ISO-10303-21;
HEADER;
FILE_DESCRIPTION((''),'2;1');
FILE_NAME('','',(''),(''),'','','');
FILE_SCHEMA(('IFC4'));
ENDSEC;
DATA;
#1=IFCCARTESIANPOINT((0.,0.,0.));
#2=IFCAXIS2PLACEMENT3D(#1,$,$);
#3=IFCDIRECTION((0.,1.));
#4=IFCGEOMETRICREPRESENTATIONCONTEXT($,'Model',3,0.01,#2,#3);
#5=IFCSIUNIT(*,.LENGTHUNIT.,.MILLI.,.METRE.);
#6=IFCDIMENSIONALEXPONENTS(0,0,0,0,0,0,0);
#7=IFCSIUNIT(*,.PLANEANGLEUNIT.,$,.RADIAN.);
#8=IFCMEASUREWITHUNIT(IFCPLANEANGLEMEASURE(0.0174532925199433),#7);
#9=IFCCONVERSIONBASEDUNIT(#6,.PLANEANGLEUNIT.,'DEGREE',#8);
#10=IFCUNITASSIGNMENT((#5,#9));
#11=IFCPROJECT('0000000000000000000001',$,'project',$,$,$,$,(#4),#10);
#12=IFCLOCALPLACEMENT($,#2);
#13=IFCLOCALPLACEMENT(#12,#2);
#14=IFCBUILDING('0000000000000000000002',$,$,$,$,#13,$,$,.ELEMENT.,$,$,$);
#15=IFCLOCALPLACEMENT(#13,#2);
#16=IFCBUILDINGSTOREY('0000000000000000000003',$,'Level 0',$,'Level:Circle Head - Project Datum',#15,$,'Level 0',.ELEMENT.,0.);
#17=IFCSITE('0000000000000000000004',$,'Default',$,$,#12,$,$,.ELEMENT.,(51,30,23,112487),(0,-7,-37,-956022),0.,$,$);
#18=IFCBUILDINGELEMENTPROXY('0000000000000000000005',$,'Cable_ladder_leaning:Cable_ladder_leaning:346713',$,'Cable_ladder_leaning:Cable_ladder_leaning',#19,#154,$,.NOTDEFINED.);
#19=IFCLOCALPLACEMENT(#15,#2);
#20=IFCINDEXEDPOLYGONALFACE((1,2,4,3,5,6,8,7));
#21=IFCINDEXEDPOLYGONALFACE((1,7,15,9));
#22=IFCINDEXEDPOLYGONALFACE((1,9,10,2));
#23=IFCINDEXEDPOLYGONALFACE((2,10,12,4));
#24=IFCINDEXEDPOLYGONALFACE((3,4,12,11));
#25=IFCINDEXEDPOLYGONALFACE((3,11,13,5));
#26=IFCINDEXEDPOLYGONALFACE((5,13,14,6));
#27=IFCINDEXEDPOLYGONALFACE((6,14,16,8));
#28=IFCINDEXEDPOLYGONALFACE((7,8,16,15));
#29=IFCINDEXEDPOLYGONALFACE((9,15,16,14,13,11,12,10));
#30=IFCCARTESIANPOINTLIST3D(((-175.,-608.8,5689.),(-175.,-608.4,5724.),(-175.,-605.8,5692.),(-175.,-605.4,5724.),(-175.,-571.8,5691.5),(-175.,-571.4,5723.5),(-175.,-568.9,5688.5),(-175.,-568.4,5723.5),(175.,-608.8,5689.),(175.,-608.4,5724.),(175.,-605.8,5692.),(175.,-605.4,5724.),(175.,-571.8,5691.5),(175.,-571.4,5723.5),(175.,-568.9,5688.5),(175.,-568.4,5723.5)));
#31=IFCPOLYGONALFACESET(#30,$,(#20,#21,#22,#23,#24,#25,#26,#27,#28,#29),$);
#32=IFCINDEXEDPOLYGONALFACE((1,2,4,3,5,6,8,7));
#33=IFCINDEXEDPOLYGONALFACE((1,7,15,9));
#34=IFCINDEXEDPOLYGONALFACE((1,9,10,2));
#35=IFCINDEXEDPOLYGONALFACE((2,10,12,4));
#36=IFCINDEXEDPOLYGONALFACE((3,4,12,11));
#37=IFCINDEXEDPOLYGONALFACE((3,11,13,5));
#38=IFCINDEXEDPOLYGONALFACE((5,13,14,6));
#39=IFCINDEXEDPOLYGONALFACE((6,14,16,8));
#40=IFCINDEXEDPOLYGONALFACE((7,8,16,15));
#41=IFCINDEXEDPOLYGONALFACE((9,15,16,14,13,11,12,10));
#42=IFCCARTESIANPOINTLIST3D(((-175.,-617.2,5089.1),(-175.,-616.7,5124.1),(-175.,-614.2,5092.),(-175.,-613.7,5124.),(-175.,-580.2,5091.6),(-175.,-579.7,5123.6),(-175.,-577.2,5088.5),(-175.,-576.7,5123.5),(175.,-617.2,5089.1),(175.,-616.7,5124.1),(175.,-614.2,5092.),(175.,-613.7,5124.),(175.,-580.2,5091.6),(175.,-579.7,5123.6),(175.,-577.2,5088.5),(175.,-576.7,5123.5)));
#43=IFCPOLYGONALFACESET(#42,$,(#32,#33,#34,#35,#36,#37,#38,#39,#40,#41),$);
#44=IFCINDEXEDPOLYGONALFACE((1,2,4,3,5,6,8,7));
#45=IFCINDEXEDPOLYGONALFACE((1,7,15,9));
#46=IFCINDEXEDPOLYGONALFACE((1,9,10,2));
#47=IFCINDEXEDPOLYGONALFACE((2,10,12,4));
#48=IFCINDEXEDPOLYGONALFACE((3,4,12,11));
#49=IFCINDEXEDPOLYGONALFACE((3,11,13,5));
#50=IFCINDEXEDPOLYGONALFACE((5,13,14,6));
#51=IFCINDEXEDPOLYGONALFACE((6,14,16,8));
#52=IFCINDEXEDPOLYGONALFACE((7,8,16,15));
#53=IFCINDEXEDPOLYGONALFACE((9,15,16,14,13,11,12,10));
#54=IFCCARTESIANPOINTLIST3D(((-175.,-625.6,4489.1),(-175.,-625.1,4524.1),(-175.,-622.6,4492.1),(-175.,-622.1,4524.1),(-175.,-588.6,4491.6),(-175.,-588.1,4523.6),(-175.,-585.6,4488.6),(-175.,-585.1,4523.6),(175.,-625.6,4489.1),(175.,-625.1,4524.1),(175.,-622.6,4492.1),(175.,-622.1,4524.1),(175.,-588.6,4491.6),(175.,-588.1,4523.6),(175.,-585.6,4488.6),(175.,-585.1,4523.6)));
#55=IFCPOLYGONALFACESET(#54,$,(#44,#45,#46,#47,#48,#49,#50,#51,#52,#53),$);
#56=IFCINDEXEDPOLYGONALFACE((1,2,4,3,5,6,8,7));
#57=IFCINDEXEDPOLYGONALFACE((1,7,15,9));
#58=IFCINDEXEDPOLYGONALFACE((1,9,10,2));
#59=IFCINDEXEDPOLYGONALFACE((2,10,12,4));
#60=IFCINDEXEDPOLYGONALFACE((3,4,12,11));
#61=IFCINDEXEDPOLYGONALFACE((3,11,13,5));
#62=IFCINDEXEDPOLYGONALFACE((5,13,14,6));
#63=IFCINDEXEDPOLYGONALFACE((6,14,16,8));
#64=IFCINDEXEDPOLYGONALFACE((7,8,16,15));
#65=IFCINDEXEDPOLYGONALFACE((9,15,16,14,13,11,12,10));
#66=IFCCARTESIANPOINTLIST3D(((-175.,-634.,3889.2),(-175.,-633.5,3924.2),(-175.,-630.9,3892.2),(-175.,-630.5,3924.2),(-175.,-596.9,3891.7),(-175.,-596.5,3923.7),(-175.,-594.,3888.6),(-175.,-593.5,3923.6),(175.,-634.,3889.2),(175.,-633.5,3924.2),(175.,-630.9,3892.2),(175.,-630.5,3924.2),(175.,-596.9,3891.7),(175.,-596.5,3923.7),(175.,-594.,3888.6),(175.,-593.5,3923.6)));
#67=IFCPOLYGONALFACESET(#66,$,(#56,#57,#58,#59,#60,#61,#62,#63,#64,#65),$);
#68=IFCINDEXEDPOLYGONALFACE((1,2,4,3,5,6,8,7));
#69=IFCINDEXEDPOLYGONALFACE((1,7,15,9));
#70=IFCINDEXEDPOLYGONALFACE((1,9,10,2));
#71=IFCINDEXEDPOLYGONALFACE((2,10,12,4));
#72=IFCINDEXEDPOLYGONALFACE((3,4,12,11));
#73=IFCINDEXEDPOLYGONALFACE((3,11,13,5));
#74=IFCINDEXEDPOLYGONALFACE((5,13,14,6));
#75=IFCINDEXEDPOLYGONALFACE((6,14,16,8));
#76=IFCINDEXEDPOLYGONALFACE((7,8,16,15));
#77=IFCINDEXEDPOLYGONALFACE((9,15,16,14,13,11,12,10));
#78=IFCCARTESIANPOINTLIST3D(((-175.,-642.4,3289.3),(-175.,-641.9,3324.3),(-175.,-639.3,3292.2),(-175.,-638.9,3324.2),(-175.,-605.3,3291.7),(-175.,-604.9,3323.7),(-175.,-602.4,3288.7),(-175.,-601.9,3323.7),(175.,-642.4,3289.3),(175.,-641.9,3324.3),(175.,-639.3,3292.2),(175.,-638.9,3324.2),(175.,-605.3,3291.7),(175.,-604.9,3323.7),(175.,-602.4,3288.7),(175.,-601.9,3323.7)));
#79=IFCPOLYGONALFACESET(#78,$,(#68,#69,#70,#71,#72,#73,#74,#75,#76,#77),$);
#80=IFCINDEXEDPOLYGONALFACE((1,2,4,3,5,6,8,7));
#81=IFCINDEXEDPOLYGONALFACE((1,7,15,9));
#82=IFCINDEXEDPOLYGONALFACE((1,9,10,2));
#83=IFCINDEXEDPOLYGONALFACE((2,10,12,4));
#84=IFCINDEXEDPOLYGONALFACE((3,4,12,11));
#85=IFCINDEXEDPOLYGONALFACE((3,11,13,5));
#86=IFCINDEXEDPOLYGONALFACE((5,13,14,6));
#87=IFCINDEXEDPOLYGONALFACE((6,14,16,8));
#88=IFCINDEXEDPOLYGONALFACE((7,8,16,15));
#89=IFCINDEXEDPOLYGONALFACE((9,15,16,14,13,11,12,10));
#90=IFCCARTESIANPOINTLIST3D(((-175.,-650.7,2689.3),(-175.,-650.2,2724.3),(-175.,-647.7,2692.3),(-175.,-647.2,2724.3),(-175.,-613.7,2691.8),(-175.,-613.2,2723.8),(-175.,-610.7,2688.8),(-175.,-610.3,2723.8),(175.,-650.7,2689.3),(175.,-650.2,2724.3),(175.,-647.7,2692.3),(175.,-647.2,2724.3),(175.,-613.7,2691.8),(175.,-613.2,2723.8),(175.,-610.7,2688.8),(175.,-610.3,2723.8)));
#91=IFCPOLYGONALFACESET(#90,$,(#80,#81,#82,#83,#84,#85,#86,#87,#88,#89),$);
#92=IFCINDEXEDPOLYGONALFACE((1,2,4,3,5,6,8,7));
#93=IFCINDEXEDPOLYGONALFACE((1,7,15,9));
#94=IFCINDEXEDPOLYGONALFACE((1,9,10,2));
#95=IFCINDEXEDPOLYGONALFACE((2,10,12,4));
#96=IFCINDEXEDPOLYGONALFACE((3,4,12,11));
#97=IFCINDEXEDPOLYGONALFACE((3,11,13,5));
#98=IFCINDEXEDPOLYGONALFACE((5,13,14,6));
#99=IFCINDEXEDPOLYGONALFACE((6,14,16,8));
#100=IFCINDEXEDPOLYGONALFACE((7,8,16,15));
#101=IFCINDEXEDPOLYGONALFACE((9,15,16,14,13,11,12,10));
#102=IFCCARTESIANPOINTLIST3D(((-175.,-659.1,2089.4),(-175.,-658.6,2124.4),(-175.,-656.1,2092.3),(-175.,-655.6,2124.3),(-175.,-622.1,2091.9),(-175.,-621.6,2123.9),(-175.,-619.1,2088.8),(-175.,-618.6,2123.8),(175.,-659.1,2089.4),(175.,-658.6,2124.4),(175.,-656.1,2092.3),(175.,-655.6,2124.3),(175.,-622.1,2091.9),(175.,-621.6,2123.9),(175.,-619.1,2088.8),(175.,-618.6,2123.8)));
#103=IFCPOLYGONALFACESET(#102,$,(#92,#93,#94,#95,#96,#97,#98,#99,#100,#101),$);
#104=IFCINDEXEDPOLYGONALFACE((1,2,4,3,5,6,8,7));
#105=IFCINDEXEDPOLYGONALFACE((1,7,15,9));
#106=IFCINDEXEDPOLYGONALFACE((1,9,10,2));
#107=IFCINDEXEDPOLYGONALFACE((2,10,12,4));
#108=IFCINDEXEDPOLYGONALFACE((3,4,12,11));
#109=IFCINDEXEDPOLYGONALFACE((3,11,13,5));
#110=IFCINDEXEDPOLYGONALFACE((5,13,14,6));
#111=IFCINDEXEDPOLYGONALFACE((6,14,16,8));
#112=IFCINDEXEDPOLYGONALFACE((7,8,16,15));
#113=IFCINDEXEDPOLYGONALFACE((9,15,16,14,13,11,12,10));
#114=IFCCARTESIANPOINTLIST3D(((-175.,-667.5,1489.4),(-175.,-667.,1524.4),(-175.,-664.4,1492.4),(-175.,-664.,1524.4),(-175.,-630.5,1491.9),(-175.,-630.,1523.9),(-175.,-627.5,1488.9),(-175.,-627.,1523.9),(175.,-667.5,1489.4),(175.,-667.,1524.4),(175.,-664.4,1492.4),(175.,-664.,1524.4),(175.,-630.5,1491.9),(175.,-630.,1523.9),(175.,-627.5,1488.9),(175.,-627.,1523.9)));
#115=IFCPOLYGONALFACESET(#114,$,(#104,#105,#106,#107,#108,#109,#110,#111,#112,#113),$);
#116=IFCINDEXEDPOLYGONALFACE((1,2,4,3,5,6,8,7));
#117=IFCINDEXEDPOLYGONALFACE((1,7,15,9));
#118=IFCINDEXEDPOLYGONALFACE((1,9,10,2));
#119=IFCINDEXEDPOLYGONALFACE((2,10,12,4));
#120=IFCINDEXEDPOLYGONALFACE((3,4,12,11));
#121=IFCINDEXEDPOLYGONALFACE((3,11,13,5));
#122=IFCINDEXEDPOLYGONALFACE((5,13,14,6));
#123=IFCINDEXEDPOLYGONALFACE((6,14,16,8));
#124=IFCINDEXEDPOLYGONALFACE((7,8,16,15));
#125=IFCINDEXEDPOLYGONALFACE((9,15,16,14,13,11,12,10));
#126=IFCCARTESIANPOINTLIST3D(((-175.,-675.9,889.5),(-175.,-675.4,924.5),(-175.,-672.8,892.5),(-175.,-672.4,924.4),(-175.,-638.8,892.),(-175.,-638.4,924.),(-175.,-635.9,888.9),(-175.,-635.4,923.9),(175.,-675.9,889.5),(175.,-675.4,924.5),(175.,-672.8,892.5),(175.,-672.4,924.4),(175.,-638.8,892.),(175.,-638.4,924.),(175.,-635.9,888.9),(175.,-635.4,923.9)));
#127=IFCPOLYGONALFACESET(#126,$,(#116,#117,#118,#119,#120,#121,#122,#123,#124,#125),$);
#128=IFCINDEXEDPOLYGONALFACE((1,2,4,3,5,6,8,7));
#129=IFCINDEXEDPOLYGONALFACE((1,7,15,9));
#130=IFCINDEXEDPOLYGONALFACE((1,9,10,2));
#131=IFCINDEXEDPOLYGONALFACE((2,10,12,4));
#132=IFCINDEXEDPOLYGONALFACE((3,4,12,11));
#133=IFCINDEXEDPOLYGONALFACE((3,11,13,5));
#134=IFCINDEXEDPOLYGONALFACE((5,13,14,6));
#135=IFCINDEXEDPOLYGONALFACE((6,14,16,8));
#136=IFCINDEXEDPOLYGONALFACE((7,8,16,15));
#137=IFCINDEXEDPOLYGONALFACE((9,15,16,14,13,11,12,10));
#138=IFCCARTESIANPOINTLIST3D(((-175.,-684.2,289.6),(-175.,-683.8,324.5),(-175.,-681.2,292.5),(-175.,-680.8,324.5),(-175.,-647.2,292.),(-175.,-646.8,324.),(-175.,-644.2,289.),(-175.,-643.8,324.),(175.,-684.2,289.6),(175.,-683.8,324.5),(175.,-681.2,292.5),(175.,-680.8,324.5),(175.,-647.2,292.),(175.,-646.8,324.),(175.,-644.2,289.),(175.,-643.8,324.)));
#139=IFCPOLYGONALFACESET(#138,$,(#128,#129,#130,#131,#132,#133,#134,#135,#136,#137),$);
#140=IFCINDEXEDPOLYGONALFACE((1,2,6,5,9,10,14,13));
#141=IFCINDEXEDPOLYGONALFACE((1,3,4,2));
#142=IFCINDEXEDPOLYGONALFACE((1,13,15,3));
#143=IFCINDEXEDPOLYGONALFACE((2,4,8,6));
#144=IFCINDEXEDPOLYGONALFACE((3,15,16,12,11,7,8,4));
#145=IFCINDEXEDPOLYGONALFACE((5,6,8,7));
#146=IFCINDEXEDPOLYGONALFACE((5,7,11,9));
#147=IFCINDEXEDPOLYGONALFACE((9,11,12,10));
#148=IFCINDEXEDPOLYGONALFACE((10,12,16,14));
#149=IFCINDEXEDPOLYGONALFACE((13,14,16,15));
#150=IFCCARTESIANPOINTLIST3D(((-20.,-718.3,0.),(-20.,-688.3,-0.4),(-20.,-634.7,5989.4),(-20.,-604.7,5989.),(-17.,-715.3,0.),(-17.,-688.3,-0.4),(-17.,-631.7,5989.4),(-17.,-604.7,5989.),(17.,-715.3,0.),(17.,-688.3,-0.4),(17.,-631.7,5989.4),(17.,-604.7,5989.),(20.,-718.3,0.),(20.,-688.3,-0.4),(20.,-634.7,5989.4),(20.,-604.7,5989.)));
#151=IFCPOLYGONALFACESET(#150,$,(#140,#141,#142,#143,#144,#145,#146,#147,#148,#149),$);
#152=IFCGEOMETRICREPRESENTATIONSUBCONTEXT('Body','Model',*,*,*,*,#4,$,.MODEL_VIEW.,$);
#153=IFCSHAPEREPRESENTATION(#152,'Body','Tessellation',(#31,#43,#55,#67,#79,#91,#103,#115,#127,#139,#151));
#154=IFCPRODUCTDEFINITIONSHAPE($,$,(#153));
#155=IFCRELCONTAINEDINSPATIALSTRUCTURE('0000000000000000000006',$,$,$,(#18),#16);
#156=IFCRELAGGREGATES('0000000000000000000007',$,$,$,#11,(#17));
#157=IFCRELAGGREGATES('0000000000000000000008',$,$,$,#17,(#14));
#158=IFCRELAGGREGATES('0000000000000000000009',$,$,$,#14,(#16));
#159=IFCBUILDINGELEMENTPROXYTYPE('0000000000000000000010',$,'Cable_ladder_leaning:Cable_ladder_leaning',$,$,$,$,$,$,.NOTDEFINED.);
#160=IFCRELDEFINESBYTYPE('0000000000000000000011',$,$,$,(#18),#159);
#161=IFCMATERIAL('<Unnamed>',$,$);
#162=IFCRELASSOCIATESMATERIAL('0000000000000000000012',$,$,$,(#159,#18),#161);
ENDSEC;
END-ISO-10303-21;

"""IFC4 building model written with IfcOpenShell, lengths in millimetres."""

from ifc_helpers import new_model, entity, si_unit, converted_unit, direction, frame, origin, place, context, subcontext, project, spatial, indexed_curve, outline, extrude, source, transform, mapped, material, type_object, type_shapes, element, save


model = new_model("IFC4")

# Units and contexts
model_context = context("Model", 3, precision=0.01, world=origin(), true_north=direction((0.0, 1.0)))
body_context = subcontext(model_context, "Body", "Model", "MODEL_VIEW")
ifc_project = project(units=[si_unit("LENGTHUNIT", "METRE", prefix="MILLI"), converted_unit("PLANEANGLEUNIT", "DEGREE", entity("IfcPlaneAngleMeasure", 0.0174532925199433), si_unit("PLANEANGLEUNIT", "RADIAN"), dimensions=[0, 0, 0, 0, 0, 0, 0])], contexts=[model_context])

# Site, building, storey
site_placement = place(None, origin())
site = spatial("IfcSite", under=ifc_project, at=site_placement, Name="Default", CompositionType="ELEMENT", RefLatitude=(51, 30, 23, 112487), RefLongitude=(0, -7, -37, -956022), RefElevation=0.0)
building_placement = place(site_placement, origin())
building = spatial("IfcBuilding", under=site, at=building_placement, CompositionType="ELEMENT")
storey_placement = place(building_placement, origin())
storey = spatial("IfcBuildingStorey", under=building, at=storey_placement, Name="Level 0", ObjectType="Level:Circle Head - Project Datum", LongName="Level 0", CompositionType="ELEMENT", Elevation=0.0)

# Shared definitions
ifc_material_1 = material(Name="<Unnamed>")

# Building element proxy
building_element_proxy_type_1 = type_object("IfcBuildingElementProxyType", Name="Cable_ladder_leaning:Cable_ladder_leaning", PredefinedType="NOTDEFINED", material=ifc_material_1)
shared_shape_1 = source(origin(), body_context, "Body", "SweptSolid", [
    extrude(outline(indexed_curve([(-20.0, -18.2), (20.0, -18.2), (20.0, 16.8), (17.0, 16.8), (17.0, -15.2), (-17.0, -15.2), (-17.0, 16.8), (-20.0, 16.8), (-20.0, -18.2)], self_intersect=False)), frame((-175.0, 129.7, 5707.0), z_axis=(1.0, 0.0, 0.0), x_axis=(0.0, 0.999903, -0.013962)), (0.0, 0.0, 1.0), 350.0),
    extrude(outline(indexed_curve([(-20.0, -18.2), (20.0, -18.2), (20.0, 16.7), (17.0, 16.8), (17.0, -15.2), (-17.0, -15.3), (-17.0, 16.8), (-20.0, 16.7), (-20.0, -18.2)], self_intersect=False)), frame((-175.0, 121.3, 5107.1), z_axis=(1.0, 0.0, 0.0), x_axis=(0.0, 0.999903, -0.013962)), (0.0, 0.0, 1.0), 350.0),
    extrude(outline(indexed_curve([(-20.0, -18.2), (20.0, -18.2), (20.0, 16.8), (17.0, 16.8), (17.0, -15.2), (-17.0, -15.2), (-17.0, 16.8), (-20.0, 16.8), (-20.0, -18.2)], self_intersect=False)), frame((-175.0, 112.9, 4507.1), z_axis=(1.0, 0.0, 0.0), x_axis=(0.0, 0.999903, -0.013962)), (0.0, 0.0, 1.0), 350.0),
    extrude(outline(indexed_curve([(-20.0, -18.2), (20.0, -18.2), (20.0, 16.8), (17.0, 16.7), (17.0, -15.2), (-17.0, -15.3), (-17.0, 16.7), (-20.0, 16.8), (-20.0, -18.2)], self_intersect=False)), frame((-175.0, 104.6, 3907.2), z_axis=(1.0, 0.0, 0.0), x_axis=(0.0, 0.999903, -0.013962)), (0.0, 0.0, 1.0), 350.0),
    extrude(outline(indexed_curve([(-20.0, -18.2), (20.0, -18.2), (20.0, 16.8), (17.0, 16.7), (17.0, -15.2), (-17.0, -15.3), (-17.0, 16.8), (-20.0, 16.8), (-20.0, -18.2)], self_intersect=False)), frame((-175.0, 96.2, 3307.2), z_axis=(1.0, 0.0, 0.0), x_axis=(0.0, 0.999903, -0.013962)), (0.0, 0.0, 1.0), 350.0),
    extrude(outline(indexed_curve([(-20.0, -18.2), (20.0, -18.2), (20.0, 16.8), (17.0, 16.7), (17.0, -15.2), (-17.0, -15.3), (-17.0, 16.8), (-20.0, 16.8), (-20.0, -18.2)], self_intersect=False)), frame((-175.0, 87.8, 2707.3), z_axis=(1.0, 0.0, 0.0), x_axis=(0.0, 0.999903, -0.013962)), (0.0, 0.0, 1.0), 350.0),
    extrude(outline(indexed_curve([(-20.0, -18.2), (20.0, -18.2), (20.0, 16.7), (17.0, 16.7), (17.0, -15.2), (-17.0, -15.2), (-17.0, 16.8), (-20.0, 16.8), (-20.0, -18.2)], self_intersect=False)), frame((-175.0, 79.4, 2107.3), z_axis=(1.0, 0.0, 0.0), x_axis=(0.0, 0.999903, -0.013962)), (0.0, 0.0, 1.0), 350.0),
    extrude(outline(indexed_curve([(-20.0, -18.2), (20.0, -18.2), (20.0, 16.7), (17.0, 16.7), (17.0, -15.2), (-17.0, -15.2), (-17.0, 16.8), (-20.0, 16.8), (-20.0, -18.2)], self_intersect=False)), frame((-175.0, 71.1, 1507.4), z_axis=(1.0, 0.0, 0.0), x_axis=(0.0, 0.999903, -0.013962)), (0.0, 0.0, 1.0), 350.0),
    extrude(outline(indexed_curve([(-20.0, -18.2), (20.0, -18.2), (20.0, 16.7), (17.0, 16.7), (17.0, -15.3), (-17.0, -15.3), (-17.0, 16.7), (-20.0, 16.7), (-20.0, -18.2)], self_intersect=False)), frame((-175.0, 62.7, 907.5), z_axis=(1.0, 0.0, 0.0), x_axis=(0.0, 0.999903, -0.013962)), (0.0, 0.0, 1.0), 350.0),
    extrude(outline(indexed_curve([(-20.0, -18.2), (20.0, -18.2), (20.0, 16.7), (17.0, 16.7), (17.0, -15.3), (-17.0, -15.3), (-17.0, 16.7), (-20.0, 16.7), (-20.0, -18.2)], self_intersect=False)), frame((-175.0, 54.3, 307.5), z_axis=(1.0, 0.0, 0.0), x_axis=(0.0, 0.999903, -0.013962)), (0.0, 0.0, 1.0), 350.0),
    extrude(outline(indexed_curve([(-14.2, -20.0), (15.8, -20.0), (15.8, 20.0), (-14.2, 20.0), (-14.2, 17.0), (12.8, 17.0), (12.7, -17.0), (-14.2, -17.0), (-14.2, -20.0)], self_intersect=False)), frame((0.0, 15.7, -0.2), z_axis=(0.0, 0.013962, 0.999903), x_axis=(0.0, -0.999903, 0.013962)), (0.0, 0.0, 1.0), 5990.0),
])
type_shapes(building_element_proxy_type_1, [shared_shape_1])
proxy_1_placement = place(storey_placement, frame((0.0, -718.3, 0.0)))
element("IfcBuildingElementProxy", 1, at=proxy_1_placement, inside=storey, type_object=building_element_proxy_type_1, material=ifc_material_1, Name="Cable_ladder_leaning:Cable_ladder_leaning:346713", ObjectType="Cable_ladder_leaning:Cable_ladder_leaning", PredefinedType="NOTDEFINED", context=body_context, shape_type="MappedRepresentation", body=[
    mapped(shared_shape_1, transform((0.0, 0.0, 0.0), scale=1.0)),
])

save(model, "model.ifc")
